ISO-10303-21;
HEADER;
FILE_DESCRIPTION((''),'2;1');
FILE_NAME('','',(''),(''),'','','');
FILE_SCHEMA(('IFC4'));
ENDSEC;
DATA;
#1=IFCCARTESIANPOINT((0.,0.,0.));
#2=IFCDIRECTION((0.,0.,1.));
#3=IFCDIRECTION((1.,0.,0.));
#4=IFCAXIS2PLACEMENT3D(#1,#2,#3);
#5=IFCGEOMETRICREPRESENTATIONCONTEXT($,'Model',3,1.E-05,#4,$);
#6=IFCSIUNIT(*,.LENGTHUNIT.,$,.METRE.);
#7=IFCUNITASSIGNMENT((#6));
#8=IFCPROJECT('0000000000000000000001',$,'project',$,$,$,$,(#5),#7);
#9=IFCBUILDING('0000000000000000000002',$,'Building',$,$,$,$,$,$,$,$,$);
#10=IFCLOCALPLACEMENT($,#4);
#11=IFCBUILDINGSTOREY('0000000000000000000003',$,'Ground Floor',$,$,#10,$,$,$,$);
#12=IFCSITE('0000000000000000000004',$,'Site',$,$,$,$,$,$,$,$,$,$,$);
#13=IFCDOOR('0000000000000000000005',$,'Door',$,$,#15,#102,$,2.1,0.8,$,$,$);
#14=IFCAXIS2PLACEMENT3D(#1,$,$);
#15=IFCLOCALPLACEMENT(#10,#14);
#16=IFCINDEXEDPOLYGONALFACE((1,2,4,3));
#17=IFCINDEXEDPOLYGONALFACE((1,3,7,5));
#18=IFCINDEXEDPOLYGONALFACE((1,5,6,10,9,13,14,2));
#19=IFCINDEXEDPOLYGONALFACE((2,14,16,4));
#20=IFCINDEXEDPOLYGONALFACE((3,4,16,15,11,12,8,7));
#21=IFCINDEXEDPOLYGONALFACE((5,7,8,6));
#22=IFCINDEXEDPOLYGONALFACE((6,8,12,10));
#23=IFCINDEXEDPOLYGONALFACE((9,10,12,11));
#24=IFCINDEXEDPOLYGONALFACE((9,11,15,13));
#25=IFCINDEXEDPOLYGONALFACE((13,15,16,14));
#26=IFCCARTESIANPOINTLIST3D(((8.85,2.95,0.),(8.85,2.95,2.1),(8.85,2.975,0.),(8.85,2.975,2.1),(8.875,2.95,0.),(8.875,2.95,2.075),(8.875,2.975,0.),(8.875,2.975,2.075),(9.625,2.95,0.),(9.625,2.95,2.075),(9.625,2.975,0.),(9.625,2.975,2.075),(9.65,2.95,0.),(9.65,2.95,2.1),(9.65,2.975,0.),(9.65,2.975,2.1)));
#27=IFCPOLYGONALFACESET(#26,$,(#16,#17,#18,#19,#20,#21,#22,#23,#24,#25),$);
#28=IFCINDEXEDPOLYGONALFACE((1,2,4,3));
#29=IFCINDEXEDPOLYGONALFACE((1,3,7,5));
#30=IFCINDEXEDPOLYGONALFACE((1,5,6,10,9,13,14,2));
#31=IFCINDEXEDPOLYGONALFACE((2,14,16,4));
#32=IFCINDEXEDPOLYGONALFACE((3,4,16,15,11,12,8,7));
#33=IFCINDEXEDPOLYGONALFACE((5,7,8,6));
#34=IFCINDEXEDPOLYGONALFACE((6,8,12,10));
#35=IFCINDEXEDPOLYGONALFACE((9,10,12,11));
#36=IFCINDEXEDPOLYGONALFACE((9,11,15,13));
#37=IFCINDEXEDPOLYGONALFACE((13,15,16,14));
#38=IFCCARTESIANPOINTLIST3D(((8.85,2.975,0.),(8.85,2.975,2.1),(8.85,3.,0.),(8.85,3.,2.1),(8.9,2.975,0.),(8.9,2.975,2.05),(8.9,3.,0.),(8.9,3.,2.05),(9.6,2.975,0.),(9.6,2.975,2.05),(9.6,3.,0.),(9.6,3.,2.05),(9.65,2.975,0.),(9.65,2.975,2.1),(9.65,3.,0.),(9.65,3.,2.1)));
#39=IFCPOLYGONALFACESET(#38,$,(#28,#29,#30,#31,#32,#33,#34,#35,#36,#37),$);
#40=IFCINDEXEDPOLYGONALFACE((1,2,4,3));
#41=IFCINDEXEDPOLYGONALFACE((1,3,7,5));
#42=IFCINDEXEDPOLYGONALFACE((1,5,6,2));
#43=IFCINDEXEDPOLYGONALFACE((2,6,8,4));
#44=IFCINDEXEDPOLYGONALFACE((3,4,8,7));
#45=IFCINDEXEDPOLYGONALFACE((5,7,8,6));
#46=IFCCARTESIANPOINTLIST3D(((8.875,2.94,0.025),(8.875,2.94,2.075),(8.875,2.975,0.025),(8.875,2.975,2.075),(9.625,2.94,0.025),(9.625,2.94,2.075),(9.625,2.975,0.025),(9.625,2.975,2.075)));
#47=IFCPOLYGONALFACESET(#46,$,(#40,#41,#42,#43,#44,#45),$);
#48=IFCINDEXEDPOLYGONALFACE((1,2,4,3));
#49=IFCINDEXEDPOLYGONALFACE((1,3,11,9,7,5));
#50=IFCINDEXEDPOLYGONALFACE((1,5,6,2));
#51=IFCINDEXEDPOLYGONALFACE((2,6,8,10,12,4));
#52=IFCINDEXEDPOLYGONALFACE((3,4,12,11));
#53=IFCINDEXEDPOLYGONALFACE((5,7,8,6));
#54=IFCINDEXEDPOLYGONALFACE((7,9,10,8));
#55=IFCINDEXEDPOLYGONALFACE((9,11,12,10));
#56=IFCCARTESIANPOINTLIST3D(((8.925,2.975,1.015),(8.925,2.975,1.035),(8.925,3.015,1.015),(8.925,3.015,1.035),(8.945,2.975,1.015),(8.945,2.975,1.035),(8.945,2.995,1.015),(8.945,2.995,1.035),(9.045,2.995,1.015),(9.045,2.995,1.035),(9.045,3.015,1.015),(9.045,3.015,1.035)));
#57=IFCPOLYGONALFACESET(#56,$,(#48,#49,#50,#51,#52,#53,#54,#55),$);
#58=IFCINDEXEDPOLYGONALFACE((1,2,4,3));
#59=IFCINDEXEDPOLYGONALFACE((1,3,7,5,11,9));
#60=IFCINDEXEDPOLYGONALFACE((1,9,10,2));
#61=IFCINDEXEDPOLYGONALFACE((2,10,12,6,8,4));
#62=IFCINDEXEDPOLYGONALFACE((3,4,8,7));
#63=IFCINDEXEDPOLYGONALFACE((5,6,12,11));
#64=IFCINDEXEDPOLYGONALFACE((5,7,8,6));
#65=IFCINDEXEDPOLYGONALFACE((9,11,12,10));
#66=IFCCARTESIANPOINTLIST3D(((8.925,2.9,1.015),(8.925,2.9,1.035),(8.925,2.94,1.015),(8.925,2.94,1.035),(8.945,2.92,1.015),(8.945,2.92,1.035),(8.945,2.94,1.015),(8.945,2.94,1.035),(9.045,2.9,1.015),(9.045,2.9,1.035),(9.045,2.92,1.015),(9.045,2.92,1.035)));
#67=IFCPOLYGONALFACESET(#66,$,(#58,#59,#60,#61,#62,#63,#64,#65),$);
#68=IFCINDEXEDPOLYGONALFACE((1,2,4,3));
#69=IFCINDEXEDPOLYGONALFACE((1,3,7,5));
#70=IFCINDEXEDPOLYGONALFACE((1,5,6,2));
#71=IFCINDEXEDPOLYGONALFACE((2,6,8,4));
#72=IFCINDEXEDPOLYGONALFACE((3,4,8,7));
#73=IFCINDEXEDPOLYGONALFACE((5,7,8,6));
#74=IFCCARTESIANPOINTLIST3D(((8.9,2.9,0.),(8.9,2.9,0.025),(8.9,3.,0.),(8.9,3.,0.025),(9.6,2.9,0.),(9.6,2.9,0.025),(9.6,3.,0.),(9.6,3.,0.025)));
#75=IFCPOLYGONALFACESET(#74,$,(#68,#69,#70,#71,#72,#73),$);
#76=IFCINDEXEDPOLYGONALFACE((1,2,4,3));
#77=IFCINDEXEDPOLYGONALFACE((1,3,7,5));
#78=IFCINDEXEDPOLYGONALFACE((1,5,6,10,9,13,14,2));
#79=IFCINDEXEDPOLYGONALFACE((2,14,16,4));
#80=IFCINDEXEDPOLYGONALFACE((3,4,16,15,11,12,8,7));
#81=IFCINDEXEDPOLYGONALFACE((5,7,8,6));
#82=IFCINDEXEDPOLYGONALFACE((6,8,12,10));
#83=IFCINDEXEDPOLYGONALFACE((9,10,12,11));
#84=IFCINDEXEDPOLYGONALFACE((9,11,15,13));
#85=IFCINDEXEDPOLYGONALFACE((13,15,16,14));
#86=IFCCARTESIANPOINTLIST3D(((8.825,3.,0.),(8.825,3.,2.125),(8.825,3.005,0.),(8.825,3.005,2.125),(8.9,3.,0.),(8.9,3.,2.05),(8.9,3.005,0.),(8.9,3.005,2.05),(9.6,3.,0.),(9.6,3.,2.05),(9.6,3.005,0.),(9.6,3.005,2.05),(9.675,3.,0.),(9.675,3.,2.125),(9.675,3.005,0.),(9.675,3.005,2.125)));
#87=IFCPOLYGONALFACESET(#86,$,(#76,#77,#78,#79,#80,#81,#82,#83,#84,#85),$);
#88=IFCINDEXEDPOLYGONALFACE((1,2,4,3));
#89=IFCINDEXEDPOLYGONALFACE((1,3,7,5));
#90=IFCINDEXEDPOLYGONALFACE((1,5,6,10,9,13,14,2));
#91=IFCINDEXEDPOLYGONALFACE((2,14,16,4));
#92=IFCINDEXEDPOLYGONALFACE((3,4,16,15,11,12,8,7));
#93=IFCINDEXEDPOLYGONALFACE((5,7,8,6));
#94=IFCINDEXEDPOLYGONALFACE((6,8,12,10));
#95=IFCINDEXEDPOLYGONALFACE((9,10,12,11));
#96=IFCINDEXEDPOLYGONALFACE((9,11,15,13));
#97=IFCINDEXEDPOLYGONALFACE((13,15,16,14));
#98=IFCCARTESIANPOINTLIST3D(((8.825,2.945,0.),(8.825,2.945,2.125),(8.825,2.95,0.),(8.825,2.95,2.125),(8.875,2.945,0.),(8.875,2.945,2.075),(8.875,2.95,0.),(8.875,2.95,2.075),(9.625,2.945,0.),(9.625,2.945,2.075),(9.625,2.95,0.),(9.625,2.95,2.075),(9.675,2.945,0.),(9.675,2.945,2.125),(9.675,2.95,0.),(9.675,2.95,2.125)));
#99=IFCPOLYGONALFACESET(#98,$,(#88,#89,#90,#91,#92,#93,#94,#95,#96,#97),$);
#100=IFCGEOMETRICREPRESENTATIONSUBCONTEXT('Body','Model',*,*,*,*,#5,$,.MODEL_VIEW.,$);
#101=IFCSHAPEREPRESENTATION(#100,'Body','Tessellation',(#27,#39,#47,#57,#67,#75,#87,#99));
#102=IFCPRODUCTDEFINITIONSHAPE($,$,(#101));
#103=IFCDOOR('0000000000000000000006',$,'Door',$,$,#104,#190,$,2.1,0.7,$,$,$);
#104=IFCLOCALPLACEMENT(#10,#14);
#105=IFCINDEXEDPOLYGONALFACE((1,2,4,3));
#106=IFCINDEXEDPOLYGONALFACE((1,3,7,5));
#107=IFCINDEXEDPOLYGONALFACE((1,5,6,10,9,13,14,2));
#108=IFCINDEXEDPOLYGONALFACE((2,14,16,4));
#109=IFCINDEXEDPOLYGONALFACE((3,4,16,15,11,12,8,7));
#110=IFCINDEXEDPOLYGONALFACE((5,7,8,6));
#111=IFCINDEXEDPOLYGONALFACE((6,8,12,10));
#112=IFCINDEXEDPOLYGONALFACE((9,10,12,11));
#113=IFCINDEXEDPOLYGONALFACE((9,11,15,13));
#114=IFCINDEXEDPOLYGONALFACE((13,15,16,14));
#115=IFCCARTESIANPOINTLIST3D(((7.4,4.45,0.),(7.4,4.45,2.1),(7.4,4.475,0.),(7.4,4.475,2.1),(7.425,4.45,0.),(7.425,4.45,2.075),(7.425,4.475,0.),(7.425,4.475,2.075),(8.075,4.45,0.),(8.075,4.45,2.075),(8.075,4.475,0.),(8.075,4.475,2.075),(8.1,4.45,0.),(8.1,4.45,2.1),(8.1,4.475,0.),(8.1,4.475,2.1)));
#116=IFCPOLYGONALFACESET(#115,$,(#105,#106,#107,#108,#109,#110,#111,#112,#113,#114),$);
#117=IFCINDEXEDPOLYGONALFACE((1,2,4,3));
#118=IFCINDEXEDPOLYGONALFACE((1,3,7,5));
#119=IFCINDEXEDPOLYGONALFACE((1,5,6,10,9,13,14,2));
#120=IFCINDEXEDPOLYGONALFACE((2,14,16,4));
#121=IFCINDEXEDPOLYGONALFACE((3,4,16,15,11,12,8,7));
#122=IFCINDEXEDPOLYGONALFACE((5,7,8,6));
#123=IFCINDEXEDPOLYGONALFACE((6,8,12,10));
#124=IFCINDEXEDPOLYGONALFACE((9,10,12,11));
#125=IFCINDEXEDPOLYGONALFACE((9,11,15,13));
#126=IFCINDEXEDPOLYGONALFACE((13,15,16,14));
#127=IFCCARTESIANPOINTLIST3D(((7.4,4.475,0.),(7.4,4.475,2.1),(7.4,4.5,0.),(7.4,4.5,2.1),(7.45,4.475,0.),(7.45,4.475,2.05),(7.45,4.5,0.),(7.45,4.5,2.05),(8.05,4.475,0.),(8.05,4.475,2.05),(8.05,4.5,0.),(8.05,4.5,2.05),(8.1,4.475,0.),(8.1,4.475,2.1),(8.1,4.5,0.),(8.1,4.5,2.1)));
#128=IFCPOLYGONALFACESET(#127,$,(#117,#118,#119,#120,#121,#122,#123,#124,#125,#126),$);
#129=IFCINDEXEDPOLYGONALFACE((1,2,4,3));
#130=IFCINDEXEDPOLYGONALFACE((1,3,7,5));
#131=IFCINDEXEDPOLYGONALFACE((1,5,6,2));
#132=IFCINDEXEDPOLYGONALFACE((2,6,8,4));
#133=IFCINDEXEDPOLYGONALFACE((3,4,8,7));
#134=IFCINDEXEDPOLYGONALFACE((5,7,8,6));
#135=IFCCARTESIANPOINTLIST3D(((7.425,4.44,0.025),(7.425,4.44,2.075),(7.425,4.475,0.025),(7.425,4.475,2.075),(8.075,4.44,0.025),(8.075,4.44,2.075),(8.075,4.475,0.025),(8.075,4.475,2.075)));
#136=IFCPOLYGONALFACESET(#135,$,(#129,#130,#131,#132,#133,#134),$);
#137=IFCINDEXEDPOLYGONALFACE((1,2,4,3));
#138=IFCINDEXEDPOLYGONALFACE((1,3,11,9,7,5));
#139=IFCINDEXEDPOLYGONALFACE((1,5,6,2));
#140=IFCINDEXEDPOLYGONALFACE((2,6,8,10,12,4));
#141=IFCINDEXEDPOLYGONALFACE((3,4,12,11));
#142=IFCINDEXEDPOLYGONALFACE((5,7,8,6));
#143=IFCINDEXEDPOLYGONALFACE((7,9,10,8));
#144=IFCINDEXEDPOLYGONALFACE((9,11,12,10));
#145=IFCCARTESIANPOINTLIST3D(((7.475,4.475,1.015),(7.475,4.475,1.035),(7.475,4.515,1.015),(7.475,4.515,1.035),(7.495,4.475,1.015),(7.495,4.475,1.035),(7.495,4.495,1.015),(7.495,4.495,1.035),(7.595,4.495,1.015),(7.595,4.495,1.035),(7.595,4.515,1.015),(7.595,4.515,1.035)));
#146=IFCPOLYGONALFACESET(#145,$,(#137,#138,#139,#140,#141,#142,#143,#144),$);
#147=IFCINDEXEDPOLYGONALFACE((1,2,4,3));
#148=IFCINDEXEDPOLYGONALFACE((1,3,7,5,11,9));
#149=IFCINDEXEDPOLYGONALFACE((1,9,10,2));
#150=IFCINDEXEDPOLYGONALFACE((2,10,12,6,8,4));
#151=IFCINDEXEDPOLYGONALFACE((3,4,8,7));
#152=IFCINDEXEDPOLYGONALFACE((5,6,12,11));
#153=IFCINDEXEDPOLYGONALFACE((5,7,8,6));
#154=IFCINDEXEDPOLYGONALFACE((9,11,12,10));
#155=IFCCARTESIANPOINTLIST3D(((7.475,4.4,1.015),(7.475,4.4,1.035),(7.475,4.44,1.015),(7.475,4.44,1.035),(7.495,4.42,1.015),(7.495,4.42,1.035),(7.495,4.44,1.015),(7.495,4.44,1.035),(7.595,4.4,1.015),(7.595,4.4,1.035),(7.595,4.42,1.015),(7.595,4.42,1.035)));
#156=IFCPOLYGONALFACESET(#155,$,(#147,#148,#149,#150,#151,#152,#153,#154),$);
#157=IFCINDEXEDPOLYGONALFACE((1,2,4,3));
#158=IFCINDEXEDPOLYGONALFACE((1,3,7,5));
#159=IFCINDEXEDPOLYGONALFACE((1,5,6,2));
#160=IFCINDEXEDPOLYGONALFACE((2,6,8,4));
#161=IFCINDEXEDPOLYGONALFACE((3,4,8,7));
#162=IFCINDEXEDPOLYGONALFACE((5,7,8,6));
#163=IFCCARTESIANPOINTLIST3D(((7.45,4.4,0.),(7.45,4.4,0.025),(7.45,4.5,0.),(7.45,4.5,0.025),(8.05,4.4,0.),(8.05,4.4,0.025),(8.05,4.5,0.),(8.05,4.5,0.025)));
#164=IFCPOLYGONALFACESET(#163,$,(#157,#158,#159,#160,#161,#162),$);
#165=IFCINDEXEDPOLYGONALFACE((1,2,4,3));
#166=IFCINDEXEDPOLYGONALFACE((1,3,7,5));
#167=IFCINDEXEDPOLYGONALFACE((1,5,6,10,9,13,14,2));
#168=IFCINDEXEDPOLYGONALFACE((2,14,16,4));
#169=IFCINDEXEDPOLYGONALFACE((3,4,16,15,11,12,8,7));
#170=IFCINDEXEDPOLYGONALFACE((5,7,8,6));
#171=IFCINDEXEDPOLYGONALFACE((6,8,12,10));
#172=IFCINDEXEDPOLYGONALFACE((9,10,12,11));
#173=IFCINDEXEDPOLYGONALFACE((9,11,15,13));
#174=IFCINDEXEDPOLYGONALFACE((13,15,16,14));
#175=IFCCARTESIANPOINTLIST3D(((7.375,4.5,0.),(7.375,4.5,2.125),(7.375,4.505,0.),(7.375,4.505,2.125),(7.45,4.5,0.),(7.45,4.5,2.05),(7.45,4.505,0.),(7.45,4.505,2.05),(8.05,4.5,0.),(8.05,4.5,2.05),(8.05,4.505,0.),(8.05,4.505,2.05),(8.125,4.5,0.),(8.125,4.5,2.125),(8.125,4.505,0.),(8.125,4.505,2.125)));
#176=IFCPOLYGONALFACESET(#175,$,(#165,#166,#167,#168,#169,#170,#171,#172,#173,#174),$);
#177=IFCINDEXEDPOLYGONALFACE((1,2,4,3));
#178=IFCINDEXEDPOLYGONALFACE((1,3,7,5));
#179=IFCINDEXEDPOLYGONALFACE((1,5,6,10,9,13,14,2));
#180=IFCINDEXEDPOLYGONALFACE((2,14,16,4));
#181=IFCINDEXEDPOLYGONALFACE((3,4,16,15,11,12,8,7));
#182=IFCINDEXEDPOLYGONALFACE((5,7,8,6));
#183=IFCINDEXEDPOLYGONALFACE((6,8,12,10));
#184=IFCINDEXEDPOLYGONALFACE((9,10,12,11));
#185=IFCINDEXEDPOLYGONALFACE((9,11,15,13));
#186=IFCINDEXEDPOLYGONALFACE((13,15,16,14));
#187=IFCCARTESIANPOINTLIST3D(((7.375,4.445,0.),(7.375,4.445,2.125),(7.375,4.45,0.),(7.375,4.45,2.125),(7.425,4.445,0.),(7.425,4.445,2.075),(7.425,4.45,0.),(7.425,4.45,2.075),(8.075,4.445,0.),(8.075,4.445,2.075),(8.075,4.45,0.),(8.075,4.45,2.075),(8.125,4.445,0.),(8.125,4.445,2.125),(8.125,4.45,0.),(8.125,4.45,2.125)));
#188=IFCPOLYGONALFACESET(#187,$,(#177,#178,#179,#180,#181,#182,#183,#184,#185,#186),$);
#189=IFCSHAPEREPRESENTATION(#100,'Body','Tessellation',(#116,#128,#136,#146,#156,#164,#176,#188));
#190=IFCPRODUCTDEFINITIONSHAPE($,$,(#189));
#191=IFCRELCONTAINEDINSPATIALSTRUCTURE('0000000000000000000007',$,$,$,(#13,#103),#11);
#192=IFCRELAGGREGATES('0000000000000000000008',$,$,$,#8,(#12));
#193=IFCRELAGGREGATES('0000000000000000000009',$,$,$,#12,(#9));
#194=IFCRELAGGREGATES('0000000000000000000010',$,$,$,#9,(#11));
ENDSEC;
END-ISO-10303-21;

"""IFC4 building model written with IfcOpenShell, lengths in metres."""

from ifc_helpers import new_model, si_unit, frame, origin_with_axes, place, context, subcontext, project, spatial, line, indexed_curve, outline, extrude, element, save


model = new_model("IFC4")

# Units and contexts
model_context = context("Model", 3, precision=1e-05, world=origin_with_axes())
body_context = subcontext(model_context, "Body", "Model", "MODEL_VIEW")
ifc_project = project(units=[si_unit("LENGTHUNIT", "METRE")], contexts=[model_context])

# Site, building, storey
site = spatial("IfcSite", under=ifc_project, Name="Site")
building = spatial("IfcBuilding", under=site, Name="Building")
storey_placement = place(None, origin_with_axes())
storey = spatial("IfcBuildingStorey", under=building, at=storey_placement, Name="Ground Floor")

# Doors
door_1_placement = place(storey_placement, frame((9.65, 3.0, 0.0), z_axis=(0.0, 0.0, 1.0), x_axis=(-1.0, 0.0, 0.0)))
element("IfcDoor", 1, at=door_1_placement, inside=storey, Name="Door", OverallHeight=2.1, OverallWidth=0.8, context=body_context, shape_type="SweptSolid", body=[
    extrude(outline(indexed_curve([(0.0, 0.0), (0.0, 2.1), (0.8, 2.1), (0.8, 0.0), (0.775, 0.0), (0.775, 2.075), (0.025, 2.075), (0.025, 0.0)], segments=[line(1, 2, 3, 4, 5, 6, 7, 8, 1)])), frame((0.0, 0.025, 0.0), z_axis=(0.0, -1.0, 0.0), x_axis=(1.0, 0.0, 0.0)), (0.0, 0.0, -1.0), 0.025),
    extrude(outline(indexed_curve([(0.0, 0.0), (0.0, 2.1), (0.8, 2.1), (0.8, 0.0), (0.75, 0.0), (0.75, 2.05), (0.05, 2.05), (0.05, 0.0)], segments=[line(1, 2, 3, 4, 5, 6, 7, 8, 1)])), frame((0.0, 0.0, 0.0), z_axis=(0.0, -1.0, 0.0), x_axis=(1.0, 0.0, 0.0)), (0.0, 0.0, -1.0), 0.025),
    extrude(outline(indexed_curve([(0.0, 0.0), (0.75, 0.0), (0.75, 0.035), (0.0, 0.035)], segments=[line(1, 2, 3, 4, 1)])), frame((0.025, 0.025, 0.025), z_axis=(0.0, 0.0, 1.0), x_axis=(1.0, 0.0, 0.0)), (0.0, 0.0, 1.0), 2.05),
    extrude(outline(indexed_curve([(0.0, 0.0), (0.0, -0.04), (-0.12, -0.04), (-0.12, -0.02), (-0.02, -0.02), (-0.02, 0.0)], segments=[line(1, 2, 3, 4, 5, 6, 1)])), frame((0.725, 0.025, 1.015), z_axis=(0.0, 0.0, 1.0), x_axis=(1.0, 0.0, 0.0)), (0.0, 0.0, 1.0), 0.02),
    extrude(outline(indexed_curve([(0.0, 0.0), (0.0, 0.04), (-0.12, 0.04), (-0.12, 0.02), (-0.02, 0.02), (-0.02, 0.0)], segments=[line(1, 2, 3, 4, 5, 6, 1)])), frame((0.725, 0.06, 1.015), z_axis=(0.0, 0.0, 1.0), x_axis=(1.0, 0.0, 0.0)), (0.0, 0.0, 1.0), 0.02),
    extrude(outline(indexed_curve([(0.0, 0.0), (0.7, 0.0), (0.7, 0.1), (0.0, 0.1)], segments=[line(1, 2, 3, 4, 1)])), frame((0.05, 0.0, 0.0), z_axis=(0.0, 0.0, 1.0), x_axis=(1.0, 0.0, 0.0)), (0.0, 0.0, 1.0), 0.025),
    extrude(outline(indexed_curve([(0.0, 0.0), (0.0, 2.125), (0.85, 2.125), (0.85, 0.0), (0.775, 0.0), (0.775, 2.05), (0.075, 2.05), (0.075, 0.0)], segments=[line(1, 2, 3, 4, 5, 6, 7, 8, 1)])), frame((-0.025, -0.005, 0.0), z_axis=(0.0, -1.0, 0.0), x_axis=(1.0, 0.0, 0.0)), (0.0, 0.0, -1.0), 0.005),
    extrude(outline(indexed_curve([(0.0, 0.0), (0.0, 2.125), (0.85, 2.125), (0.85, 0.0), (0.8, 0.0), (0.8, 2.075), (0.05, 2.075), (0.05, 0.0)], segments=[line(1, 2, 3, 4, 5, 6, 7, 8, 1)])), frame((-0.025, 0.05, 0.0), z_axis=(0.0, -1.0, 0.0), x_axis=(1.0, 0.0, 0.0)), (0.0, 0.0, -1.0), 0.005),
])
door_2_placement = place(storey_placement, frame((8.1, 4.5, 0.0), z_axis=(0.0, 0.0, 1.0), x_axis=(-1.0, 0.0, 0.0)))
element("IfcDoor", 2, at=door_2_placement, inside=storey, Name="Door", OverallHeight=2.1, OverallWidth=0.7, context=body_context, shape_type="SweptSolid", body=[
    extrude(outline(indexed_curve([(0.0, 0.0), (0.0, 2.1), (0.7, 2.1), (0.7, 0.0), (0.675, 0.0), (0.675, 2.075), (0.025, 2.075), (0.025, 0.0)], segments=[line(1, 2, 3, 4, 5, 6, 7, 8, 1)])), frame((0.0, 0.025, 0.0), z_axis=(0.0, -1.0, 0.0), x_axis=(1.0, 0.0, 0.0)), (0.0, 0.0, -1.0), 0.025),
    extrude(outline(indexed_curve([(0.0, 0.0), (0.0, 2.1), (0.7, 2.1), (0.7, 0.0), (0.65, 0.0), (0.65, 2.05), (0.05, 2.05), (0.05, 0.0)], segments=[line(1, 2, 3, 4, 5, 6, 7, 8, 1)])), frame((0.0, 0.0, 0.0), z_axis=(0.0, -1.0, 0.0), x_axis=(1.0, 0.0, 0.0)), (0.0, 0.0, -1.0), 0.025),
    extrude(outline(indexed_curve([(0.0, 0.0), (0.65, 0.0), (0.65, 0.035), (0.0, 0.035)], segments=[line(1, 2, 3, 4, 1)])), frame((0.025, 0.025, 0.025), z_axis=(0.0, 0.0, 1.0), x_axis=(1.0, 0.0, 0.0)), (0.0, 0.0, 1.0), 2.05),
    extrude(outline(indexed_curve([(0.0, 0.0), (0.0, -0.04), (-0.12, -0.04), (-0.12, -0.02), (-0.02, -0.02), (-0.02, 0.0)], segments=[line(1, 2, 3, 4, 5, 6, 1)])), frame((0.625, 0.025, 1.015), z_axis=(0.0, 0.0, 1.0), x_axis=(1.0, 0.0, 0.0)), (0.0, 0.0, 1.0), 0.02),
    extrude(outline(indexed_curve([(0.0, 0.0), (0.0, 0.04), (-0.12, 0.04), (-0.12, 0.02), (-0.02, 0.02), (-0.02, 0.0)], segments=[line(1, 2, 3, 4, 5, 6, 1)])), frame((0.625, 0.06, 1.015), z_axis=(0.0, 0.0, 1.0), x_axis=(1.0, 0.0, 0.0)), (0.0, 0.0, 1.0), 0.02),
    extrude(outline(indexed_curve([(0.0, 0.0), (0.6, 0.0), (0.6, 0.1), (0.0, 0.1)], segments=[line(1, 2, 3, 4, 1)])), frame((0.05, 0.0, 0.0), z_axis=(0.0, 0.0, 1.0), x_axis=(1.0, 0.0, 0.0)), (0.0, 0.0, 1.0), 0.025),
    extrude(outline(indexed_curve([(0.0, 0.0), (0.0, 2.125), (0.75, 2.125), (0.75, 0.0), (0.675, 0.0), (0.675, 2.05), (0.075, 2.05), (0.075, 0.0)], segments=[line(1, 2, 3, 4, 5, 6, 7, 8, 1)])), frame((-0.025, -0.005, 0.0), z_axis=(0.0, -1.0, 0.0), x_axis=(1.0, 0.0, 0.0)), (0.0, 0.0, -1.0), 0.005),
    extrude(outline(indexed_curve([(0.0, 0.0), (0.0, 2.125), (0.75, 2.125), (0.75, 0.0), (0.7, 0.0), (0.7, 2.075), (0.05, 2.075), (0.05, 0.0)], segments=[line(1, 2, 3, 4, 5, 6, 7, 8, 1)])), frame((-0.025, 0.05, 0.0), z_axis=(0.0, -1.0, 0.0), x_axis=(1.0, 0.0, 0.0)), (0.0, 0.0, -1.0), 0.005),
])

save(model, "model.ifc")
